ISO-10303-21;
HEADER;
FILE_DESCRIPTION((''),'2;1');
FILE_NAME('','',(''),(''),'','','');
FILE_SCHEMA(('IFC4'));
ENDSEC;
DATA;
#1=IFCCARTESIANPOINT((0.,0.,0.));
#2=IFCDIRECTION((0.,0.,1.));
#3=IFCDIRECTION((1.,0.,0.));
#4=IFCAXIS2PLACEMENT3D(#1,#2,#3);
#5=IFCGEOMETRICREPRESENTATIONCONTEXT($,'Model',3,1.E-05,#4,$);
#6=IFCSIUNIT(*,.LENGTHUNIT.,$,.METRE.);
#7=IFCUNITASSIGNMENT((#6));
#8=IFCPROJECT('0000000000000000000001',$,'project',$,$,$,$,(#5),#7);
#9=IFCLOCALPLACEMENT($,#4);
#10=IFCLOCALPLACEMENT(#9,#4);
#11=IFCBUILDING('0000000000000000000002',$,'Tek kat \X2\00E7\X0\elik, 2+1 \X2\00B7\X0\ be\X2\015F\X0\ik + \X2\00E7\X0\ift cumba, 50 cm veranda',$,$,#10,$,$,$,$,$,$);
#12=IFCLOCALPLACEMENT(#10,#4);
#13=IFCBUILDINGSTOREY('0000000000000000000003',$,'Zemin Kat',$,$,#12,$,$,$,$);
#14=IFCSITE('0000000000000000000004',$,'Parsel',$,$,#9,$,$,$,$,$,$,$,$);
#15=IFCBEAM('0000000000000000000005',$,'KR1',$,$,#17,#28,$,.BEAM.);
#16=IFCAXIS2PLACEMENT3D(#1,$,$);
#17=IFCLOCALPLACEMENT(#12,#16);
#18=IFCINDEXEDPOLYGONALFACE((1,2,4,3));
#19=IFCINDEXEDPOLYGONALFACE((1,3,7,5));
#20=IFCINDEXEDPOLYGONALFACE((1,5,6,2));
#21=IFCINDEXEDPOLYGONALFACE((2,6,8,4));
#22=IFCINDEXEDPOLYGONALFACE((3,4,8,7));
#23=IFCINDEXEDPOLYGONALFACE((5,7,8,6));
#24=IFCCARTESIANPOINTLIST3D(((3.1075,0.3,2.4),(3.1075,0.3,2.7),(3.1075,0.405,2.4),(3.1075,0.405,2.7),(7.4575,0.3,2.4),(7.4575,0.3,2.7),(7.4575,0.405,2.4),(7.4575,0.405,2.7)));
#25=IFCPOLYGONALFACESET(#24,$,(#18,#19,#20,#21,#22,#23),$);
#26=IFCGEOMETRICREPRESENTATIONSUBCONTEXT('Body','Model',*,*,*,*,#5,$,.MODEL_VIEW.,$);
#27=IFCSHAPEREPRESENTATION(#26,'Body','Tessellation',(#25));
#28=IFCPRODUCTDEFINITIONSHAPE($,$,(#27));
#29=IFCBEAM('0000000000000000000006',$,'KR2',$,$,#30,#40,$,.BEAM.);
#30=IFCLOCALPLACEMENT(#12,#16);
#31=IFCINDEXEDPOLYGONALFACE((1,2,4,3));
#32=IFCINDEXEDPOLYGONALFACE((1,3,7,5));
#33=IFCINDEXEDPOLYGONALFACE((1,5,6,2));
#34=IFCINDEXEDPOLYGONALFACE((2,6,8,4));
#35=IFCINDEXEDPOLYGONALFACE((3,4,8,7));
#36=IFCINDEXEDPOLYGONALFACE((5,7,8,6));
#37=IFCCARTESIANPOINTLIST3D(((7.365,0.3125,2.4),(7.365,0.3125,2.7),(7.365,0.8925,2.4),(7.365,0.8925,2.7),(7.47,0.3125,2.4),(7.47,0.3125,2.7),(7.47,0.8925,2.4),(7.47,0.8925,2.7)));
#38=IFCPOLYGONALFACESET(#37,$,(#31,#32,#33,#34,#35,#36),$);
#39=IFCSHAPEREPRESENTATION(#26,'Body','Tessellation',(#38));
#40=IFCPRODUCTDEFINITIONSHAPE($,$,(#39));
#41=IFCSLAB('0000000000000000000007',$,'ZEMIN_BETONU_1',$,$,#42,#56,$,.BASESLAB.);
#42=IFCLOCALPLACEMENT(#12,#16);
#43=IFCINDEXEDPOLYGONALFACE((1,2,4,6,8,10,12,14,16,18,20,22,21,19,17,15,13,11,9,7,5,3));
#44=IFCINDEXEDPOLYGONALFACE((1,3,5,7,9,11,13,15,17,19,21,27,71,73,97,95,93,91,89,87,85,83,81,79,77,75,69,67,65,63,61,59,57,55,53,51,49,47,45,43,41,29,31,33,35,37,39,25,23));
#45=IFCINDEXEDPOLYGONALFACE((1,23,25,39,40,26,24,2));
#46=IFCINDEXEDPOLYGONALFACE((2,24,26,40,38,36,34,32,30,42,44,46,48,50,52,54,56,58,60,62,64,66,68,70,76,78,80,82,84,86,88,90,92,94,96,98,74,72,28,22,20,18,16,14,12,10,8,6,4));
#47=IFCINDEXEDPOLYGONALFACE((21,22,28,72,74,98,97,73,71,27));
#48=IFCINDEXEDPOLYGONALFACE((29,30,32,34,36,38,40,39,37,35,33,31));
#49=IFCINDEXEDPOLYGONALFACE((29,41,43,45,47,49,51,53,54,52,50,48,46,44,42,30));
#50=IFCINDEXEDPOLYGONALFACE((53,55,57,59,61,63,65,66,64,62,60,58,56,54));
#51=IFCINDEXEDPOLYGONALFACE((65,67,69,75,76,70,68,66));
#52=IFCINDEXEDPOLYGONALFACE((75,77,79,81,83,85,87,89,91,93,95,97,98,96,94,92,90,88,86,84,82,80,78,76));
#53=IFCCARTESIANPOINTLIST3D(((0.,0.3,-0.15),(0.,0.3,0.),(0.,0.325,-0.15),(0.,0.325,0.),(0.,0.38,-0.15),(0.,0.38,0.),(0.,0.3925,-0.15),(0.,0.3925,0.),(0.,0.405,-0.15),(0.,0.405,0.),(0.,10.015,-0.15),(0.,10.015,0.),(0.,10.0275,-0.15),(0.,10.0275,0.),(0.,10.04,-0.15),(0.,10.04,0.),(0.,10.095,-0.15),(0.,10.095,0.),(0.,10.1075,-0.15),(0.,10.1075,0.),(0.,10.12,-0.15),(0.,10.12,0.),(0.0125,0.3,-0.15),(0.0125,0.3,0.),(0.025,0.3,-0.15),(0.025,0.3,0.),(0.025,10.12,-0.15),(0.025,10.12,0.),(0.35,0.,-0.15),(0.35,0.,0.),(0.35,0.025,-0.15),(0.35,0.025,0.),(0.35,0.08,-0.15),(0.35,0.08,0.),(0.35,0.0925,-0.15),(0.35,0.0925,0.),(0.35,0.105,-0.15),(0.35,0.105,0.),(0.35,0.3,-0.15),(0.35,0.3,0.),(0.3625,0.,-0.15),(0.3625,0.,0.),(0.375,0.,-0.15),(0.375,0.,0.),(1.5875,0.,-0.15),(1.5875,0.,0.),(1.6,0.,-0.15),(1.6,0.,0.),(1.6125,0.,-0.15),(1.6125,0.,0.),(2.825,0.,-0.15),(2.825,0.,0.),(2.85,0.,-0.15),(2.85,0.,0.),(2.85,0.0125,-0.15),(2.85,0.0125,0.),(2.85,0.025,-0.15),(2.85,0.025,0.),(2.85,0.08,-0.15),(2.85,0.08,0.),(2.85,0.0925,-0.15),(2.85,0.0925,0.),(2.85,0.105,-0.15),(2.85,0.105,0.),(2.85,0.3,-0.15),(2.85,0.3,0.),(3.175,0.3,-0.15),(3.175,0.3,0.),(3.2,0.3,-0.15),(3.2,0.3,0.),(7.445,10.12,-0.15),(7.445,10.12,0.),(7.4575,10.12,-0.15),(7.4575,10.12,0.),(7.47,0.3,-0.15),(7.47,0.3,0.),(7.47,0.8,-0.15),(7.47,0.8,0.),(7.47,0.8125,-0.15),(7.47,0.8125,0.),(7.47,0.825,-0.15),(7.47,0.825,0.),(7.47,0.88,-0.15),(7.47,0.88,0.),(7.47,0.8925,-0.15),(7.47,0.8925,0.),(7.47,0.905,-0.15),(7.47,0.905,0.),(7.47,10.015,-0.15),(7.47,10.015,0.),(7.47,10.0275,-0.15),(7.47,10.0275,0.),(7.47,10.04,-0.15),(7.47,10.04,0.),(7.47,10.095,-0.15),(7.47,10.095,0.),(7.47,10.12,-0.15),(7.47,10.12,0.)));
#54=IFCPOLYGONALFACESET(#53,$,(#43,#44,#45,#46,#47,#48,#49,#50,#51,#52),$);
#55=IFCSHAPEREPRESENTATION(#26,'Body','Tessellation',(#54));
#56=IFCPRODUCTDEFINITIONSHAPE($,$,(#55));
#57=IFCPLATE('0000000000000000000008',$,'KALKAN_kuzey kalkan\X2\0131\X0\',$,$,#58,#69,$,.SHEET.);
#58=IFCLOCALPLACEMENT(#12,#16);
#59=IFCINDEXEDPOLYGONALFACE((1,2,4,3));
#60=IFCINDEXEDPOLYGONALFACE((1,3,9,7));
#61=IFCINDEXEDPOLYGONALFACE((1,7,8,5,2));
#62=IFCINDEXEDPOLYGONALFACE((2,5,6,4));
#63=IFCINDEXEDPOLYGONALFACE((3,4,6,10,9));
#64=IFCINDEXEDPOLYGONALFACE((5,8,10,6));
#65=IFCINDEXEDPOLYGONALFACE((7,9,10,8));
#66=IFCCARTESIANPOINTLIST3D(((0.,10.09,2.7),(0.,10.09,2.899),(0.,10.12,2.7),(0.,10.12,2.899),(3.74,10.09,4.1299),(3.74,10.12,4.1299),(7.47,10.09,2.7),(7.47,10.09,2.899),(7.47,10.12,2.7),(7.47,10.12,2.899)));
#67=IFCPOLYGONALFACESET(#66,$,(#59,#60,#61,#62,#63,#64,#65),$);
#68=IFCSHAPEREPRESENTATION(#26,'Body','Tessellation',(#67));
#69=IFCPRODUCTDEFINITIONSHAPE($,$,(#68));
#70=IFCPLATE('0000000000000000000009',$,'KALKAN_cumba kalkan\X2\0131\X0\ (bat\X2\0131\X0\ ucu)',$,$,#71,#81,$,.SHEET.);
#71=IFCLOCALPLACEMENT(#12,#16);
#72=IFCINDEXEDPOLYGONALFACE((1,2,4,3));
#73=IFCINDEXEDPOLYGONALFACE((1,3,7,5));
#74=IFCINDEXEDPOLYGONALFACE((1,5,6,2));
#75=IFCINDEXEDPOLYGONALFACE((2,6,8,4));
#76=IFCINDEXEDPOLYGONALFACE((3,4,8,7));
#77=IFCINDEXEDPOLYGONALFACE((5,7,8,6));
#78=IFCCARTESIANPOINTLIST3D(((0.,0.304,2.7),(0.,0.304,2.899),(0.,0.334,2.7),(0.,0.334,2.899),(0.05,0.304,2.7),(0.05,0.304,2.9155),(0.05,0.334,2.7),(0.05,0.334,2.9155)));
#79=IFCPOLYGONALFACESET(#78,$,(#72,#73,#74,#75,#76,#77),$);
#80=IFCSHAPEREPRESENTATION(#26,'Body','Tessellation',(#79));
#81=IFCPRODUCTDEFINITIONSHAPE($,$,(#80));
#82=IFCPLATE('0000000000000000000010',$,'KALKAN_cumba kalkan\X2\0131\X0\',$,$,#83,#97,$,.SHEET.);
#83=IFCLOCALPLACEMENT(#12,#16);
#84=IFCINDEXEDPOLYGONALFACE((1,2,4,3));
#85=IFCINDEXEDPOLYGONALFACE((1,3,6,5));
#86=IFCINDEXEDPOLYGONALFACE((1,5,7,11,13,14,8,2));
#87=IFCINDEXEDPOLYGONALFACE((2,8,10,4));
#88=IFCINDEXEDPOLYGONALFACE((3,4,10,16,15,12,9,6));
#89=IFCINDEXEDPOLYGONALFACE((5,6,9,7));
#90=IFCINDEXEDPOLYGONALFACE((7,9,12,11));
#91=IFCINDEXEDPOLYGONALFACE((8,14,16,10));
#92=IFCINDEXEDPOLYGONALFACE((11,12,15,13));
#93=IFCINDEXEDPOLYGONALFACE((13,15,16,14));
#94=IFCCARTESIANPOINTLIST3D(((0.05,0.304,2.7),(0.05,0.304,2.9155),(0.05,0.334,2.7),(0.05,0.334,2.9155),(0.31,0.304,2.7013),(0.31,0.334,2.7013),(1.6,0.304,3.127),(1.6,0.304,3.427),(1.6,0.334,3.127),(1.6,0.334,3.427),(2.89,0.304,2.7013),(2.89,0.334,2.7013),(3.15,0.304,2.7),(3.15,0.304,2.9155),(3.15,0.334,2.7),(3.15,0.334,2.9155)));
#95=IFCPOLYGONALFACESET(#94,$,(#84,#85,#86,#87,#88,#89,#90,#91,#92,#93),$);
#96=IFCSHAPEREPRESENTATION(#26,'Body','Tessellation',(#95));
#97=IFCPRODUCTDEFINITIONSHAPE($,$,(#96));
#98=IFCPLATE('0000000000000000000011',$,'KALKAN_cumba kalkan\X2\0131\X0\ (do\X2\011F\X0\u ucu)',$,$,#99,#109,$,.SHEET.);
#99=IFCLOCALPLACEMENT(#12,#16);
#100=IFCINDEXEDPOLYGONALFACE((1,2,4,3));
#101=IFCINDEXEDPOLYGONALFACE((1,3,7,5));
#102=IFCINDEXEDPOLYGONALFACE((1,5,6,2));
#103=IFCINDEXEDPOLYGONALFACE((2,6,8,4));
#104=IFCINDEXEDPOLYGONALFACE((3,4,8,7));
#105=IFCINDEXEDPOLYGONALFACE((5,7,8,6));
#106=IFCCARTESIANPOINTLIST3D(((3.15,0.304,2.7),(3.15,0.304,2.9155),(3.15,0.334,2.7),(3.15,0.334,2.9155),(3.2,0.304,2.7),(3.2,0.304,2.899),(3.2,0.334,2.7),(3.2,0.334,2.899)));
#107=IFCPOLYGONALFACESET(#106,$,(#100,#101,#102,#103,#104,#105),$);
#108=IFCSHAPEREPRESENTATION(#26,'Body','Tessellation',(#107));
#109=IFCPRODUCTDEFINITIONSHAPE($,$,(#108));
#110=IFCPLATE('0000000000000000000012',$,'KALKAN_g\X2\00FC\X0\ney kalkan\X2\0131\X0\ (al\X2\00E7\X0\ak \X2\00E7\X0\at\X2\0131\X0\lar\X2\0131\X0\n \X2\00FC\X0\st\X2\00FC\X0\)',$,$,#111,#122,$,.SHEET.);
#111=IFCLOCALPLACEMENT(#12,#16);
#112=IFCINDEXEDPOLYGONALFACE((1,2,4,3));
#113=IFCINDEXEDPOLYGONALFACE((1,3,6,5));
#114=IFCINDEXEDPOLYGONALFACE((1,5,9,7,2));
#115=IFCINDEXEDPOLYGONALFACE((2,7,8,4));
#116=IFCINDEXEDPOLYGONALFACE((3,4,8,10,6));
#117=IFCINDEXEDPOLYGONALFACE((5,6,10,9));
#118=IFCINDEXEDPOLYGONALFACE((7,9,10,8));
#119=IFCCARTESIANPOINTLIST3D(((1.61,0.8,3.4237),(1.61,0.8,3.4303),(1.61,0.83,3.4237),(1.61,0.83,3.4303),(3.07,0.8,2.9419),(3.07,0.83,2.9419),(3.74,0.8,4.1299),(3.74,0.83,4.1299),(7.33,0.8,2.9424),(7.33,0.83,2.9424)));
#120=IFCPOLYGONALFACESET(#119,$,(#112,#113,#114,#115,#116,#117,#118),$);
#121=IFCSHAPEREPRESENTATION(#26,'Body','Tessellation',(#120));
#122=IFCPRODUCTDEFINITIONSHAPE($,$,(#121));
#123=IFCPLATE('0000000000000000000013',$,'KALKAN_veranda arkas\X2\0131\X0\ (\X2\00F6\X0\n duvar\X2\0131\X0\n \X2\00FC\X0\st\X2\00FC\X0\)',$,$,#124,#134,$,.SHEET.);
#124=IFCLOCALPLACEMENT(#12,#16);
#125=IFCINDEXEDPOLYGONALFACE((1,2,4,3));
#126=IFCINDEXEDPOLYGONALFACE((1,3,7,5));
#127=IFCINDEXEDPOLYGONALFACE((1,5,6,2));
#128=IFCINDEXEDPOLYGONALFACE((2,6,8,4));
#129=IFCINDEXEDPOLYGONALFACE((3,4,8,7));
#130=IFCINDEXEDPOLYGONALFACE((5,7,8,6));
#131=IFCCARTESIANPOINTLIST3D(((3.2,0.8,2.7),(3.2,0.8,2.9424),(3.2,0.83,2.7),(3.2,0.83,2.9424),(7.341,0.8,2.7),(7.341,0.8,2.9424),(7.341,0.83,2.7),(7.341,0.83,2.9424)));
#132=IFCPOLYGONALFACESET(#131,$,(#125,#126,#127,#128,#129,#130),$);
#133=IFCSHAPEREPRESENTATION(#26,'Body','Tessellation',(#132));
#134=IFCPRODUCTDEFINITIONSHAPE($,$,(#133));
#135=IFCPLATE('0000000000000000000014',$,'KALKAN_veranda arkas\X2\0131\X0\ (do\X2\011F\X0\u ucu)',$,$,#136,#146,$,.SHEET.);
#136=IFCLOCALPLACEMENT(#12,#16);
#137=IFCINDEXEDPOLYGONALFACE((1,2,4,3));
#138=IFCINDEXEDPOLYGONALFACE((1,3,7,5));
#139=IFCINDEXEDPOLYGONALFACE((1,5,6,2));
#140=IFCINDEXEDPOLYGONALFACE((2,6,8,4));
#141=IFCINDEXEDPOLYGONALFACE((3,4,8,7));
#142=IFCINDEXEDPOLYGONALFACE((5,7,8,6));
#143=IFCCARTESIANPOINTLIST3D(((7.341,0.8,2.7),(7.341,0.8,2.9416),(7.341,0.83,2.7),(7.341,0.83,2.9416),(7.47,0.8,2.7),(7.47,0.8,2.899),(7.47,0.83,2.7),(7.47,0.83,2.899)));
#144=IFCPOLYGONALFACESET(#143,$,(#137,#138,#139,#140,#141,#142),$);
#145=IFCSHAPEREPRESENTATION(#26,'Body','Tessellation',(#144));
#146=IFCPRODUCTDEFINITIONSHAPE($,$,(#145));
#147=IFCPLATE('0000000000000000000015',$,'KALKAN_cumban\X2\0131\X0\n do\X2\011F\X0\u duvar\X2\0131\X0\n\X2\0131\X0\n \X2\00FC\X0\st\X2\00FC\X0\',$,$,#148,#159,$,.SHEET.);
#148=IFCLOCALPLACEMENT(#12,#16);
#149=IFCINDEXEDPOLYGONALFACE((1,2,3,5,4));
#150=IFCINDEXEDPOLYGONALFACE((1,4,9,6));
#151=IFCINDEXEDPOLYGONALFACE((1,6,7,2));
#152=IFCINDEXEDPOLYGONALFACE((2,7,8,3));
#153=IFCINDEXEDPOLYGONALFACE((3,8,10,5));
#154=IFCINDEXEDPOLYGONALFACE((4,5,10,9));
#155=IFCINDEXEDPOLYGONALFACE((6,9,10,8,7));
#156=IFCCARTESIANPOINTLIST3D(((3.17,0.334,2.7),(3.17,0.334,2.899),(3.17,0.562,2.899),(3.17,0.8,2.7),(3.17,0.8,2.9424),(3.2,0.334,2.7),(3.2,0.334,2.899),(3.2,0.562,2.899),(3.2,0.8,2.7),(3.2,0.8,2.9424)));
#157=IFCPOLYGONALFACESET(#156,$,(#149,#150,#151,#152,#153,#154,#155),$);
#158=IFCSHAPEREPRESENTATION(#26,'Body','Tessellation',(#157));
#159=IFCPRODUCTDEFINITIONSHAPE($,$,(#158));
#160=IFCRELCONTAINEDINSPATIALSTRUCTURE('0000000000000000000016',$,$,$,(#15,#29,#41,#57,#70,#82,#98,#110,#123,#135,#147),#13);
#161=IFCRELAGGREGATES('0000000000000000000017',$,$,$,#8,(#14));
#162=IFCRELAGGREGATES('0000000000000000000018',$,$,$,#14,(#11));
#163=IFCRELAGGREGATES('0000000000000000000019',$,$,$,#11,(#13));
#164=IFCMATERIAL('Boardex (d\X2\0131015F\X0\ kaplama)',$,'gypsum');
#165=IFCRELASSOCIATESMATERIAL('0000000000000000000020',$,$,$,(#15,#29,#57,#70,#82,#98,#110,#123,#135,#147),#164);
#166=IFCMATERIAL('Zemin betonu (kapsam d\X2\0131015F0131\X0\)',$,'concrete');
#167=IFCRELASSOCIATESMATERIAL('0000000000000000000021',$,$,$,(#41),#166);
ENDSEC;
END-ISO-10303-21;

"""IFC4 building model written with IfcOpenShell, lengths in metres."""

from ifc_helpers import new_model, si_unit, frame, origin_with_axes, place, context, subcontext, project, spatial, line, indexed_curve, outline, extrude, material, element, save


model = new_model("IFC4")

# Units and contexts
model_context = context("Model", 3, precision=1e-05, world=origin_with_axes())
body_context = subcontext(model_context, "Body", "Model", "MODEL_VIEW")
ifc_project = project(units=[si_unit("LENGTHUNIT", "METRE")], contexts=[model_context])

# Site, building, storey
site_placement = place(None, origin_with_axes())
site = spatial("IfcSite", under=ifc_project, at=site_placement, Name="Parsel")
building_placement = place(site_placement, origin_with_axes())
building = spatial("IfcBuilding", under=site, at=building_placement, Name="Tek kat çelik, 2+1 · beşik + çift cumba, 50 cm veranda")
storey_placement = place(building_placement, origin_with_axes())
storey = spatial("IfcBuildingStorey", under=building, at=storey_placement, Name="Zemin Kat")

# Beams
ifc_material_1 = material(Name="Boardex (dış kaplama)", Category="gypsum")
beam_1_placement = place(storey_placement, origin_with_axes())
element("IfcBeam", 1, at=beam_1_placement, inside=storey, material=ifc_material_1, Name="KR1", PredefinedType="BEAM", context=body_context, shape_type="SweptSolid", body=[
    extrude(outline(indexed_curve([(0.0, 0.0), (4.35, 0.0), (4.35, 0.105), (0.0, 0.105)], segments=[line(1, 2, 3, 4, 1)])), frame((3.1075, 0.3, 2.4), z_axis=(0.0, 0.0, 1.0), x_axis=(1.0, 0.0, 0.0)), (0.0, 0.0, 1.0), 0.3),
])
beam_2_placement = place(storey_placement, origin_with_axes())
element("IfcBeam", 2, at=beam_2_placement, inside=storey, material=ifc_material_1, Name="KR2", PredefinedType="BEAM", context=body_context, shape_type="SweptSolid", body=[
    extrude(outline(indexed_curve([(0.0, 0.0), (0.105, 0.0), (0.105, 0.58), (0.0, 0.58)], segments=[line(1, 2, 3, 4, 1)])), frame((7.365, 0.3125, 2.4), z_axis=(0.0, 0.0, 1.0), x_axis=(1.0, 0.0, 0.0)), (0.0, 0.0, 1.0), 0.3),
])

# Slab
ifc_material_2 = material(Name="Zemin betonu (kapsam dışı)", Category="concrete")
slab_placement = place(storey_placement, origin_with_axes())
element("IfcSlab", 3, at=slab_placement, inside=storey, material=ifc_material_2, Name="ZEMIN_BETONU_1", PredefinedType="BASESLAB", context=body_context, shape_type="SweptSolid", body=[
    extrude(outline(indexed_curve([(7.47, 0.8), (7.47, 0.8125), (7.47, 0.825), (7.47, 0.88), (7.47, 0.8925), (7.47, 0.905), (7.47, 10.015), (7.47, 10.0275), (7.47, 10.04), (7.47, 10.095), (7.47, 10.12), (7.4575, 10.12), (7.445, 10.12), (0.025, 10.12), (0.0, 10.12), (0.0, 10.1075), (0.0, 10.095), (0.0, 10.04), (0.0, 10.0275), (0.0, 10.015), (0.0, 0.405), (0.0, 0.3925), (0.0, 0.38), (0.0, 0.325), (0.0, 0.3), (0.0125, 0.3), (0.025, 0.3), (0.35, 0.3), (0.35, 0.105), (0.35, 0.0925), (0.35, 0.08), (0.35, 0.025), (0.35, 0.0), (0.3625, 0.0), (0.375, 0.0), (1.5875, 0.0), (1.6, 0.0), (1.6125, 0.0), (2.825, 0.0), (2.85, 0.0), (2.85, 0.0125), (2.85, 0.025), (2.85, 0.08), (2.85, 0.0925), (2.85, 0.105), (2.85, 0.3), (3.175, 0.3), (3.2, 0.3), (7.47, 0.3)], segments=[line(1, 2, 3, 4, 5, 6, 7, 8, 9, 10, 11, 12, 13, 14, 15, 16, 17, 18, 19, 20, 21, 22, 23, 24, 25, 26, 27, 28, 29, 30, 31, 32, 33, 34, 35, 36, 37, 38, 39, 40, 41, 42, 43, 44, 45, 46, 47, 48, 49, 1)])), frame((0.0, 0.0, -0.15), z_axis=(0.0, 0.0, 1.0), x_axis=(1.0, 0.0, 0.0)), (0.0, 0.0, 1.0), 0.15),
])

# Plates
plate_1_placement = place(storey_placement, origin_with_axes())
element("IfcPlate", 4, at=plate_1_placement, inside=storey, material=ifc_material_1, Name="KALKAN_kuzey kalkanı", PredefinedType="SHEET", context=body_context, shape_type="SweptSolid", body=[
    extrude(outline(indexed_curve([(0.0, 2.899), (3.74, 4.1299), (7.47, 2.899), (7.47, 2.7), (0.0, 2.7)], segments=[line(1, 2, 3, 4, 5, 1)])), frame((0.0, 10.12, 0.0), z_axis=(0.0, -1.0, 0.0), x_axis=(1.0, 0.0, 0.0)), (0.0, 0.0, 1.0), 0.03),
])
plate_2_placement = place(storey_placement, origin_with_axes())
element("IfcPlate", 5, at=plate_2_placement, inside=storey, material=ifc_material_1, Name="KALKAN_cumba kalkanı (batı ucu)", PredefinedType="SHEET", context=body_context, shape_type="SweptSolid", body=[
    extrude(outline(indexed_curve([(0.0, 2.899), (0.05, 2.9155), (0.05, 2.7), (0.0, 2.7)], segments=[line(1, 2, 3, 4, 1)])), frame((0.0, 0.334, 0.0), z_axis=(0.0, -1.0, 0.0), x_axis=(1.0, 0.0, 0.0)), (0.0, 0.0, 1.0), 0.03),
])
plate_3_placement = place(storey_placement, origin_with_axes())
element("IfcPlate", 6, at=plate_3_placement, inside=storey, material=ifc_material_1, Name="KALKAN_cumba kalkanı", PredefinedType="SHEET", context=body_context, shape_type="SweptSolid", body=[
    extrude(outline(indexed_curve([(0.05, 2.9155), (1.6, 3.427), (3.15, 2.9155), (3.15, 2.7), (2.89, 2.7013), (1.6, 3.127), (0.31, 2.7013), (0.05, 2.7)], segments=[line(1, 2, 3, 4, 5, 6, 7, 8, 1)])), frame((0.0, 0.334, 0.0), z_axis=(0.0, -1.0, 0.0), x_axis=(1.0, 0.0, 0.0)), (0.0, 0.0, 1.0), 0.03),
])
plate_4_placement = place(storey_placement, origin_with_axes())
element("IfcPlate", 7, at=plate_4_placement, inside=storey, material=ifc_material_1, Name="KALKAN_cumba kalkanı (doğu ucu)", PredefinedType="SHEET", context=body_context, shape_type="SweptSolid", body=[
    extrude(outline(indexed_curve([(3.15, 2.9155), (3.2, 2.899), (3.2, 2.7), (3.15, 2.7)], segments=[line(1, 2, 3, 4, 1)])), frame((0.0, 0.334, 0.0), z_axis=(0.0, -1.0, 0.0), x_axis=(1.0, 0.0, 0.0)), (0.0, 0.0, 1.0), 0.03),
])
plate_5_placement = place(storey_placement, origin_with_axes())
element("IfcPlate", 8, at=plate_5_placement, inside=storey, material=ifc_material_1, Name="KALKAN_güney kalkanı (alçak çatıların üstü)", PredefinedType="SHEET", context=body_context, shape_type="SweptSolid", body=[
    extrude(outline(indexed_curve([(1.61, 3.4303), (3.74, 4.1299), (7.33, 2.9424), (3.07, 2.9419), (1.61, 3.4237)], segments=[line(1, 2, 3, 4, 5, 1)])), frame((0.0, 0.83, 0.0), z_axis=(0.0, -1.0, 0.0), x_axis=(1.0, 0.0, 0.0)), (0.0, 0.0, 1.0), 0.03),
])
plate_6_placement = place(storey_placement, origin_with_axes())
element("IfcPlate", 9, at=plate_6_placement, inside=storey, material=ifc_material_1, Name="KALKAN_veranda arkası (ön duvarın üstü)", PredefinedType="SHEET", context=body_context, shape_type="SweptSolid", body=[
    extrude(outline(indexed_curve([(3.2, 2.9424), (7.341, 2.9424), (7.341, 2.7), (3.2, 2.7)], segments=[line(1, 2, 3, 4, 1)])), frame((0.0, 0.83, 0.0), z_axis=(0.0, -1.0, 0.0), x_axis=(1.0, 0.0, 0.0)), (0.0, 0.0, 1.0), 0.03),
])
plate_7_placement = place(storey_placement, origin_with_axes())
element("IfcPlate", 10, at=plate_7_placement, inside=storey, material=ifc_material_1, Name="KALKAN_veranda arkası (doğu ucu)", PredefinedType="SHEET", context=body_context, shape_type="SweptSolid", body=[
    extrude(outline(indexed_curve([(7.341, 2.9416), (7.47, 2.899), (7.47, 2.7), (7.341, 2.7)], segments=[line(1, 2, 3, 4, 1)])), frame((0.0, 0.83, 0.0), z_axis=(0.0, -1.0, 0.0), x_axis=(1.0, 0.0, 0.0)), (0.0, 0.0, 1.0), 0.03),
])
plate_8_placement = place(storey_placement, origin_with_axes())
element("IfcPlate", 11, at=plate_8_placement, inside=storey, material=ifc_material_1, Name="KALKAN_cumbanın doğu duvarının üstü", PredefinedType="SHEET", context=body_context, shape_type="SweptSolid", body=[
    extrude(outline(indexed_curve([(0.334, 2.899), (0.562, 2.899), (0.8, 2.9424), (0.8, 2.7), (0.334, 2.7)], segments=[line(1, 2, 3, 4, 5, 1)])), frame((3.17, 0.0, 0.0), z_axis=(1.0, 0.0, 0.0), x_axis=(0.0, 1.0, 0.0)), (0.0, 0.0, 1.0), 0.03),
])

save(model, "model.ifc")
